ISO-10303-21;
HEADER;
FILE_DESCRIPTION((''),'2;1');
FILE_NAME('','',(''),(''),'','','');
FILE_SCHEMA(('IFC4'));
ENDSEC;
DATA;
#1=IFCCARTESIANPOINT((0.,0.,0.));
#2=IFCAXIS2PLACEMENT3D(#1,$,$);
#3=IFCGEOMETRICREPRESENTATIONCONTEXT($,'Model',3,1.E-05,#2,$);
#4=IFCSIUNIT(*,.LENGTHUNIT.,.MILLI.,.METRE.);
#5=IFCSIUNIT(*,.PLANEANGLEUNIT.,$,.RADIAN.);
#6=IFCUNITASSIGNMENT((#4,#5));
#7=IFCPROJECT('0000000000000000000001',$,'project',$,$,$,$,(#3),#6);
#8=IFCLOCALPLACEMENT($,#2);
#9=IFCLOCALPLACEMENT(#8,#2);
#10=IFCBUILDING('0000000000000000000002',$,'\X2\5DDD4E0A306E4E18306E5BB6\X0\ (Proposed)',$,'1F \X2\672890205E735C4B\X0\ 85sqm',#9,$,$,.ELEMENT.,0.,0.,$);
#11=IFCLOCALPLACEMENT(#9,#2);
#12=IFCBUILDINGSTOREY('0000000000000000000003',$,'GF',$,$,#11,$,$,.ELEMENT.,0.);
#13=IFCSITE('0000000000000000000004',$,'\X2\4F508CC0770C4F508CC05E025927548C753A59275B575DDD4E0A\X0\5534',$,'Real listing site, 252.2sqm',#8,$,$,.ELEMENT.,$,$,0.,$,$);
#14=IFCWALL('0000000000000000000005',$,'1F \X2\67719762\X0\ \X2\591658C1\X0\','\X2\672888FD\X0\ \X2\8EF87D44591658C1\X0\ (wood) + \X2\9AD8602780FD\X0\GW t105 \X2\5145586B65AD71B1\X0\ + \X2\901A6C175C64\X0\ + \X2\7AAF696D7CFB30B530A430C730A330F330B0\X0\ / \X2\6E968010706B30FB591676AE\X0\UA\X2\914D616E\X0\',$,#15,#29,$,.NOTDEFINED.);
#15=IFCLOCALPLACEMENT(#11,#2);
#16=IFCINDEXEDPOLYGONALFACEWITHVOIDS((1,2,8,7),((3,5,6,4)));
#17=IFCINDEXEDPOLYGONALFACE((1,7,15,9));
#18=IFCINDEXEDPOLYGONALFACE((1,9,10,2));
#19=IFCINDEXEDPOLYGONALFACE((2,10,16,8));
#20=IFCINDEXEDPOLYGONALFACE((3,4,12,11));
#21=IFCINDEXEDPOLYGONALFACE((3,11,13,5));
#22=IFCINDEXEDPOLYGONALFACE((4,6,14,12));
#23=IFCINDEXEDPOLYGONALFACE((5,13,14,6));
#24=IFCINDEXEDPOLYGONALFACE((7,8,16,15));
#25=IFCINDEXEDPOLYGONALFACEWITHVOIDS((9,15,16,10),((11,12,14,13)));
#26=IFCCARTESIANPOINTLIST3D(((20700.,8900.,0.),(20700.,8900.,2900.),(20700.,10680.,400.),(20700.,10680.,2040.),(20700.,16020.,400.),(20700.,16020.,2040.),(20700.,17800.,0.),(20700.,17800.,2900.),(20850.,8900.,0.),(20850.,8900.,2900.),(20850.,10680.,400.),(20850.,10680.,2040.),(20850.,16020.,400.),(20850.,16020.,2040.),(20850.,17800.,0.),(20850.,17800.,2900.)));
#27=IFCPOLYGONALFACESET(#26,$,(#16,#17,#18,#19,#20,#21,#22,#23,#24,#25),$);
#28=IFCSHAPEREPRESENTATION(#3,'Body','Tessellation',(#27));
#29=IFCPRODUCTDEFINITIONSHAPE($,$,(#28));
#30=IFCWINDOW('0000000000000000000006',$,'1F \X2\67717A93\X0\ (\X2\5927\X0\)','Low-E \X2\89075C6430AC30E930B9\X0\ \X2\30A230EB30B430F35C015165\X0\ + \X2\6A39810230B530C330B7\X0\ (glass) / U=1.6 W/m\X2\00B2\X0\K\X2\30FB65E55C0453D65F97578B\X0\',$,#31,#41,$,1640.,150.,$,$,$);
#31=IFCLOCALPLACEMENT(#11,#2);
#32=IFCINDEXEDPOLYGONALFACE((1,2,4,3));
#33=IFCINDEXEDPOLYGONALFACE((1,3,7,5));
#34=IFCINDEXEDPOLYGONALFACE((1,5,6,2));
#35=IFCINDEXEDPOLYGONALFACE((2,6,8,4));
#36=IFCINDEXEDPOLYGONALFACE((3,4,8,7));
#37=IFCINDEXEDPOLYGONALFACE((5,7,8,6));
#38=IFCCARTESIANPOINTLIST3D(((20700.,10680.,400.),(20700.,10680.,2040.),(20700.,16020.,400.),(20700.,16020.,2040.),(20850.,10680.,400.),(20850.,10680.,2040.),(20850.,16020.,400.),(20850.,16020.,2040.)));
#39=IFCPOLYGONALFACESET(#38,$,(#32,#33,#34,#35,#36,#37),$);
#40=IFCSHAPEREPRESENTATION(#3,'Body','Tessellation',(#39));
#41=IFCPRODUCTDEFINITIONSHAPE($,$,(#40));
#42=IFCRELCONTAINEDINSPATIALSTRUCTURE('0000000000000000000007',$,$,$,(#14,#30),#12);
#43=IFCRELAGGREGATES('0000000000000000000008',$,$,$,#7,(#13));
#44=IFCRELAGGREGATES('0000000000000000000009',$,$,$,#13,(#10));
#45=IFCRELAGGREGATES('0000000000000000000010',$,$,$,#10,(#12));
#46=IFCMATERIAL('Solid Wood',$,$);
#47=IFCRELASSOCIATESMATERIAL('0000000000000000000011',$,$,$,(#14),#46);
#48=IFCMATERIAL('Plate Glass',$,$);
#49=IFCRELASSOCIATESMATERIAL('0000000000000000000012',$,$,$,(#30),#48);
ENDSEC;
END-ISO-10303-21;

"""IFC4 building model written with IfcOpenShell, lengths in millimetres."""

from ifc_helpers import new_model, si_unit, frame, frame_2d, origin, place, context, project, spatial, rectangle, extrude, material, element, fill, save


model = new_model("IFC4")

# Units and contexts
model_context = context("Model", 3, precision=1e-05, world=origin())
ifc_project = project(units=[si_unit("LENGTHUNIT", "METRE", prefix="MILLI"), si_unit("PLANEANGLEUNIT", "RADIAN")], contexts=[model_context])

# Site, building, storey
site_placement = place(None, origin())
site = spatial("IfcSite", under=ifc_project, at=site_placement, Name="佐賀県佐賀市大和町大字川上5534", ObjectType="Real listing site, 252.2sqm", CompositionType="ELEMENT", RefElevation=0.0)
building_placement = place(site_placement, origin())
building = spatial("IfcBuilding", under=site, at=building_placement, Name="川上の丘の家 (Proposed)", ObjectType="1F 木造平屋 85sqm", CompositionType="ELEMENT", ElevationOfRefHeight=0.0, ElevationOfTerrain=0.0)
storey_placement = place(building_placement, origin())
storey = spatial("IfcBuildingStorey", under=building, at=storey_placement, Name="GF", CompositionType="ELEMENT", Elevation=0.0)

# Wall, opening, window
ifc_material_1 = material(Name="Solid Wood")
wall_1_placement = place(storey_placement, frame((10350.0, 4450.0, 0.0)))
wall_1 = element("IfcWall", 1, at=wall_1_placement, inside=storey, material=ifc_material_1, Name="1F 東面 外壁", Description="木製 軸組外壁 (wood) + 高性能GW t105 充填断熱 + 通気層 + 窯業系サイディング / 準耐火・外皮UA配慮", PredefinedType="NOTDEFINED", context=model_context, shape_type="SweptSolid", body=[
    extrude(rectangle(XDim=150.0, YDim=8900.0, at=frame_2d((75.0, 4450.0))), frame((10350.0, 4450.0, 0.0)), (0.0, 0.0, 1.0), 2900.0),
])
opening_1_placement = place(storey_placement, frame((10350.0, 5340.0, 200.0)))
opening_1 = element("IfcOpeningElement", 2, at=opening_1_placement, cuts=wall_1, PredefinedType="NOTDEFINED", context=model_context, shape_type="SweptSolid", body=[
    extrude(rectangle(XDim=150.0, YDim=5340.0, at=frame_2d((75.0, 2670.0))), frame((10350.0, 5340.0, 200.0)), (0.0, 0.0, 1.0), 1640.0),
])
ifc_material_2 = material(Name="Plate Glass")
window_1_placement = place(storey_placement, frame((10350.0, 5340.0, 200.0)))
window_1 = element("IfcWindow", 3, at=window_1_placement, inside=storey, material=ifc_material_2, Name="1F 東窓 (大)", Description="Low-E 複層ガラス アルゴン封入 + 樹脂サッシ (glass) / U=1.6 W/m²K・日射取得型", OverallHeight=1640.0, OverallWidth=150.0, context=model_context, shape_type="SweptSolid", body=[
    extrude(rectangle(XDim=150.0, YDim=5340.0, at=frame_2d((75.0, 2670.0))), frame((10350.0, 5340.0, 200.0)), (0.0, 0.0, 1.0), 1640.0),
])
fill(opening_1, window_1)

save(model, "model.ifc")
